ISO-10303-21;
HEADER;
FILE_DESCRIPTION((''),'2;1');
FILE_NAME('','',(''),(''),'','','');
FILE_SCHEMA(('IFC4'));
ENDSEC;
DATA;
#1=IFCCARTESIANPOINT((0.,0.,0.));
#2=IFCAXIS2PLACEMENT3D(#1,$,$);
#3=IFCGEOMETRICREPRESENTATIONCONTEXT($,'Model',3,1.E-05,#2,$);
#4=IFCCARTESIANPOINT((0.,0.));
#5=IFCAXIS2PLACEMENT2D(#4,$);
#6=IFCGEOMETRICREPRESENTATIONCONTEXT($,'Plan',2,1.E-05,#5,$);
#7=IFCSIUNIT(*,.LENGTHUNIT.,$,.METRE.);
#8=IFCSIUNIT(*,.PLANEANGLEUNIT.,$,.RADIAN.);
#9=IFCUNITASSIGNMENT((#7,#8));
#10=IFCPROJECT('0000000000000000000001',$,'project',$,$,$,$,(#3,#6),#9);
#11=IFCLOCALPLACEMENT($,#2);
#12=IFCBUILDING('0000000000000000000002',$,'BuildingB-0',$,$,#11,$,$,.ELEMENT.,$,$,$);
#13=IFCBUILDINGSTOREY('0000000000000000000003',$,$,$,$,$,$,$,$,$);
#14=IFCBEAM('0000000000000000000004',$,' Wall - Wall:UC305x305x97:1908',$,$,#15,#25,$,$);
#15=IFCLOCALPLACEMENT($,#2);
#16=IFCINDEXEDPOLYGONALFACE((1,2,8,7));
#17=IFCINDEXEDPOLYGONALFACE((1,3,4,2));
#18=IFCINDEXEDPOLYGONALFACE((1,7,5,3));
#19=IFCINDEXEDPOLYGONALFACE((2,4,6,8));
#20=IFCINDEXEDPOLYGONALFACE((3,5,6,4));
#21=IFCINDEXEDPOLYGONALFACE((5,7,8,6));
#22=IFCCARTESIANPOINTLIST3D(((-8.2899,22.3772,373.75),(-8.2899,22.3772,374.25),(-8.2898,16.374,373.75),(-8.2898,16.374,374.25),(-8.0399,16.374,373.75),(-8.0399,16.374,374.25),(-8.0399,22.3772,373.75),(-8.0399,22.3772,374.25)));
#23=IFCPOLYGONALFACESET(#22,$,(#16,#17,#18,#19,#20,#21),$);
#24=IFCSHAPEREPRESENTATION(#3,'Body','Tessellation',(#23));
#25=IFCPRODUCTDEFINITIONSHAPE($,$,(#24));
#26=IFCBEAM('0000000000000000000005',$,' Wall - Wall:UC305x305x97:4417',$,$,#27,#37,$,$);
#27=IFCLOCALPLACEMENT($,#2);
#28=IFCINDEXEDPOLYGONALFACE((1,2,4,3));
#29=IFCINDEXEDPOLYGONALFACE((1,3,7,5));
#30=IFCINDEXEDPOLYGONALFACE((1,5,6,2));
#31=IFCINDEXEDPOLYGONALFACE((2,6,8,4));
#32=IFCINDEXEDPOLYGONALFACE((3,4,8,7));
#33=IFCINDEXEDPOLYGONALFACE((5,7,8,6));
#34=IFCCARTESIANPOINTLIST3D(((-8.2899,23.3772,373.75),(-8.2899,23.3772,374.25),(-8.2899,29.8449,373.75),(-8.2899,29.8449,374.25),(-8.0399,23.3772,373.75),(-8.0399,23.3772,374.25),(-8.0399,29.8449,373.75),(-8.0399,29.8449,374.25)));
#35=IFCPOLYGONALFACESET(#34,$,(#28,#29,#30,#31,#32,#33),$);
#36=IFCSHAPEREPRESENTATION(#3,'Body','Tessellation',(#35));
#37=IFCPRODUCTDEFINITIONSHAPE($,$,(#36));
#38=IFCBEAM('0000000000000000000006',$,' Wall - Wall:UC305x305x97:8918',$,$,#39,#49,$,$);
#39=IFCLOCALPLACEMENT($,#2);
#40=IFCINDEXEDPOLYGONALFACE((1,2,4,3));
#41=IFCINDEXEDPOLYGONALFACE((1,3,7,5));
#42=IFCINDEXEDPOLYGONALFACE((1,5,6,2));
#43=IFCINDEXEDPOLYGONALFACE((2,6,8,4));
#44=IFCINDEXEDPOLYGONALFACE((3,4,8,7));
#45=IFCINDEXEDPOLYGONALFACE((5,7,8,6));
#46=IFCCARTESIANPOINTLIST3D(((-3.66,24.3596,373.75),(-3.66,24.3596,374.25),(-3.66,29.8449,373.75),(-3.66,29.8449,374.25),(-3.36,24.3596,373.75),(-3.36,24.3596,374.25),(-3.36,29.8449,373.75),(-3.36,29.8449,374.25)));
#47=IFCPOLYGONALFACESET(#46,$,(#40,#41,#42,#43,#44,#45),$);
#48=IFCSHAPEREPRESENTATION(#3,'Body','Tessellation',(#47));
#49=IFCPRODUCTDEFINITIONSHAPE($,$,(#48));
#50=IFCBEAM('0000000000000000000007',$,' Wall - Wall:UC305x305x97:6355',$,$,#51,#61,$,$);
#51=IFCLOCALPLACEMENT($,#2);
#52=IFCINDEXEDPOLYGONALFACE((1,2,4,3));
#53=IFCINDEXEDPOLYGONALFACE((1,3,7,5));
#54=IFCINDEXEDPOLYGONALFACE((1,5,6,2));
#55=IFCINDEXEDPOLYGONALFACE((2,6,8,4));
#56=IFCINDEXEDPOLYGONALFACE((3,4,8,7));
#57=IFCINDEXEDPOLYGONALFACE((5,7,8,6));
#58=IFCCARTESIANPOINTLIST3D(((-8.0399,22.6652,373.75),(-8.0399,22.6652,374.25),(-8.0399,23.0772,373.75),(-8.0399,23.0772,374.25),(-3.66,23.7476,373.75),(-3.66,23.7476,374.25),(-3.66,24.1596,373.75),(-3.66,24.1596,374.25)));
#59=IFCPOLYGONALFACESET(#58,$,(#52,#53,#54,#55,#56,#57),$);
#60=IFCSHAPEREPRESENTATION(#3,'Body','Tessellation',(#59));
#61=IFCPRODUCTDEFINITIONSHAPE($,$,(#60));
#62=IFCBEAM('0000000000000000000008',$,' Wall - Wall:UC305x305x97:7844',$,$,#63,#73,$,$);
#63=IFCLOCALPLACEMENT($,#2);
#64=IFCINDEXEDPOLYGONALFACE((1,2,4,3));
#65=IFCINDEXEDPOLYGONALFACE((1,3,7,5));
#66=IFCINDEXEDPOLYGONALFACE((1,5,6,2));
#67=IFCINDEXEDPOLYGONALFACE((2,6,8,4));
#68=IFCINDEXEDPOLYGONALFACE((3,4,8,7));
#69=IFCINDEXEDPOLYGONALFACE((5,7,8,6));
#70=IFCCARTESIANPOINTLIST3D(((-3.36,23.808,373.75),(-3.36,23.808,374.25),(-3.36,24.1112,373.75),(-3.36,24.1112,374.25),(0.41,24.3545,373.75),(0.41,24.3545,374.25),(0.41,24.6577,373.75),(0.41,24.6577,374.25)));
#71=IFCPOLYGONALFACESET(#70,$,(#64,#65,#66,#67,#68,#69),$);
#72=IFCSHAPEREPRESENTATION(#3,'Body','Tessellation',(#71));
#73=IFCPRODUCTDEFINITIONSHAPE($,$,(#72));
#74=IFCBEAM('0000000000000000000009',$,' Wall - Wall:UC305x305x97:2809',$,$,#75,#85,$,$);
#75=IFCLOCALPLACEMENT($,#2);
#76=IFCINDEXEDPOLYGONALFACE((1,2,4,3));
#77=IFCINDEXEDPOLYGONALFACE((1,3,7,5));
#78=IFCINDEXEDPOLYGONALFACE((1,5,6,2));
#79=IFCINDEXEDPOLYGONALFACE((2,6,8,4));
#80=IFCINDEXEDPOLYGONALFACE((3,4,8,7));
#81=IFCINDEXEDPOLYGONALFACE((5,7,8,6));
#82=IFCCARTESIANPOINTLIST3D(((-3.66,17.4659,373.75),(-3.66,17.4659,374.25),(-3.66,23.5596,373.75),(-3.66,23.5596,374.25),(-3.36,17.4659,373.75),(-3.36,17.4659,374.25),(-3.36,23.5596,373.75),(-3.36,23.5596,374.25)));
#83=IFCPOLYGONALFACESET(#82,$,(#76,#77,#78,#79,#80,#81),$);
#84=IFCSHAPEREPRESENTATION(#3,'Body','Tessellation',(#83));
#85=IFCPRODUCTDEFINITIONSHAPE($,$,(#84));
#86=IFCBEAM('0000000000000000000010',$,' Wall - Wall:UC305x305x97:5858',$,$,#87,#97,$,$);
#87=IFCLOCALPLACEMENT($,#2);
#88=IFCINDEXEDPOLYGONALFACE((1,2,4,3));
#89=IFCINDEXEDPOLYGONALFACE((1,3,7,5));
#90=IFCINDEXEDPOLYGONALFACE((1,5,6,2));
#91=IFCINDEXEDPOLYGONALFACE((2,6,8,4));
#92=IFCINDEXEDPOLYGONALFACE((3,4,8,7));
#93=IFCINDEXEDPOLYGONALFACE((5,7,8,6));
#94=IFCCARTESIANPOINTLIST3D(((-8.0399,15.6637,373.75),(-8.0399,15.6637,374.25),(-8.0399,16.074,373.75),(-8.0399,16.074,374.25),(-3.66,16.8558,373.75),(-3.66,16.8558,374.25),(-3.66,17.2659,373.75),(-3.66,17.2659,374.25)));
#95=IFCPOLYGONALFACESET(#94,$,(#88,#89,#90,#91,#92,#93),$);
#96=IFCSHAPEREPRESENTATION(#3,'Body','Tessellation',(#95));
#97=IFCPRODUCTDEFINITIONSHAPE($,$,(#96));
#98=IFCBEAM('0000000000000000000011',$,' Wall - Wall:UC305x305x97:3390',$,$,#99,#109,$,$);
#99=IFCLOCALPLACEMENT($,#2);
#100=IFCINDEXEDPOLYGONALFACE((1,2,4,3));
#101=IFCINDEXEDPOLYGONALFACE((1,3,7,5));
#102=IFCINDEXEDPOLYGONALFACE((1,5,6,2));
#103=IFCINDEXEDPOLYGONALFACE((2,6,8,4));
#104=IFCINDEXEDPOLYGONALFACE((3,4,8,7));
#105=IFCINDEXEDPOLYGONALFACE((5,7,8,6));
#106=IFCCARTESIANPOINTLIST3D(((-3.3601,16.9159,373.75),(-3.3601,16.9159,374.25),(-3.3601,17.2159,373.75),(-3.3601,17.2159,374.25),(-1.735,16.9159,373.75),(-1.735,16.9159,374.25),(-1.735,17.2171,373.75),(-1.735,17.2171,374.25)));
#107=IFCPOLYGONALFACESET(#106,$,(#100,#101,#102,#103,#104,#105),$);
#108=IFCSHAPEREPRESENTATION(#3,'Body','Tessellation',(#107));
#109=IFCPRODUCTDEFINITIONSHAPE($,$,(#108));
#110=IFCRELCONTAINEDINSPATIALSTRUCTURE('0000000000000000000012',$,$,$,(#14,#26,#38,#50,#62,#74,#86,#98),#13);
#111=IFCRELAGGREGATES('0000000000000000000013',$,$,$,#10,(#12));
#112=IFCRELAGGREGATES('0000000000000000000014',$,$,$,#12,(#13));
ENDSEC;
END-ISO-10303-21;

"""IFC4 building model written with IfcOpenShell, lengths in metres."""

from ifc_helpers import new_model, si_unit, origin, origin_2d, place, context, project, spatial, polyline, outline, extrude, element, save


model = new_model("IFC4")

# Units and contexts
model_context = context("Model", 3, precision=1e-05, world=origin())
plan_context = context("Plan", 2, precision=1e-05, world=origin_2d())
ifc_project = project(units=[si_unit("LENGTHUNIT", "METRE"), si_unit("PLANEANGLEUNIT", "RADIAN")], contexts=[model_context, plan_context])

# Building, storey
building_placement = place(None, origin())
building = spatial("IfcBuilding", under=ifc_project, at=building_placement, Name="BuildingB-0", CompositionType="ELEMENT")
storey = spatial("IfcBuildingStorey", under=building)

# Beams
element("IfcBeam", 1, inside=storey, Name=" Wall - Wall:UC305x305x97:1908", context=model_context, shape_type="SweptSolid", body=[
    extrude(outline(polyline([(-8.2898, 16.374, 373.75), (-8.0399, 16.374, 373.75), (-8.0399, 22.3772, 373.75), (-8.2899, 22.3772, 373.75), (-8.2898, 16.374, 373.75)])), None, (0.0, 0.0, 1.0), 0.5),
])
element("IfcBeam", 2, inside=storey, Name=" Wall - Wall:UC305x305x97:4417", context=model_context, shape_type="SweptSolid", body=[
    extrude(outline(polyline([(-8.2899, 23.3772, 373.75), (-8.0399, 23.3772, 373.75), (-8.0399, 29.8449, 373.75), (-8.2899, 29.8449, 373.75), (-8.2899, 23.3772, 373.75)])), None, (0.0, 0.0, 1.0), 0.5),
])
element("IfcBeam", 3, inside=storey, Name=" Wall - Wall:UC305x305x97:8918", context=model_context, shape_type="SweptSolid", body=[
    extrude(outline(polyline([(-3.66, 29.8449, 373.75), (-3.36, 29.8449, 373.75), (-3.36, 24.3596, 373.75), (-3.66, 24.3596, 373.75), (-3.66, 29.8449, 373.75)])), None, (0.0, 0.0, 1.0), 0.5),
])
element("IfcBeam", 4, inside=storey, Name=" Wall - Wall:UC305x305x97:6355", context=model_context, shape_type="SweptSolid", body=[
    extrude(outline(polyline([(-3.66, 24.1596, 373.75), (-3.66, 23.7476, 373.75), (-8.0399, 22.6652, 373.75), (-8.0399, 23.0772, 373.75), (-3.66, 24.1596, 373.75)])), None, (0.0, 0.0, 1.0), 0.5),
])
element("IfcBeam", 5, inside=storey, Name=" Wall - Wall:UC305x305x97:7844", context=model_context, shape_type="SweptSolid", body=[
    extrude(outline(polyline([(-3.36, 23.808, 373.75), (0.41, 24.3545, 373.75), (0.41, 24.6577, 373.75), (-3.36, 24.1112, 373.75), (-3.36, 23.808, 373.75)])), None, (0.0, 0.0, 1.0), 0.5),
])
element("IfcBeam", 6, inside=storey, Name=" Wall - Wall:UC305x305x97:2809", context=model_context, shape_type="SweptSolid", body=[
    extrude(outline(polyline([(-3.66, 23.5596, 373.75), (-3.36, 23.5596, 373.75), (-3.36, 17.4659, 373.75), (-3.66, 17.4659, 373.75), (-3.66, 23.5596, 373.75)])), None, (0.0, 0.0, 1.0), 0.5),
])
element("IfcBeam", 7, inside=storey, Name=" Wall - Wall:UC305x305x97:5858", context=model_context, shape_type="SweptSolid", body=[
    extrude(outline(polyline([(-8.0399, 15.6637, 373.75), (-8.0399, 16.074, 373.75), (-3.66, 17.2659, 373.75), (-3.66, 16.8558, 373.75), (-8.0399, 15.6637, 373.75)])), None, (0.0, 0.0, 1.0), 0.5),
])
element("IfcBeam", 8, inside=storey, Name=" Wall - Wall:UC305x305x97:3390", context=model_context, shape_type="SweptSolid", body=[
    extrude(outline(polyline([(-3.3601, 17.2159, 373.75), (-3.3601, 16.9159, 373.75), (-1.735, 16.9159, 373.75), (-1.735, 17.2171, 373.75), (-3.3601, 17.2159, 373.75)])), None, (0.0, 0.0, 1.0), 0.5),
])

save(model, "model.ifc")
